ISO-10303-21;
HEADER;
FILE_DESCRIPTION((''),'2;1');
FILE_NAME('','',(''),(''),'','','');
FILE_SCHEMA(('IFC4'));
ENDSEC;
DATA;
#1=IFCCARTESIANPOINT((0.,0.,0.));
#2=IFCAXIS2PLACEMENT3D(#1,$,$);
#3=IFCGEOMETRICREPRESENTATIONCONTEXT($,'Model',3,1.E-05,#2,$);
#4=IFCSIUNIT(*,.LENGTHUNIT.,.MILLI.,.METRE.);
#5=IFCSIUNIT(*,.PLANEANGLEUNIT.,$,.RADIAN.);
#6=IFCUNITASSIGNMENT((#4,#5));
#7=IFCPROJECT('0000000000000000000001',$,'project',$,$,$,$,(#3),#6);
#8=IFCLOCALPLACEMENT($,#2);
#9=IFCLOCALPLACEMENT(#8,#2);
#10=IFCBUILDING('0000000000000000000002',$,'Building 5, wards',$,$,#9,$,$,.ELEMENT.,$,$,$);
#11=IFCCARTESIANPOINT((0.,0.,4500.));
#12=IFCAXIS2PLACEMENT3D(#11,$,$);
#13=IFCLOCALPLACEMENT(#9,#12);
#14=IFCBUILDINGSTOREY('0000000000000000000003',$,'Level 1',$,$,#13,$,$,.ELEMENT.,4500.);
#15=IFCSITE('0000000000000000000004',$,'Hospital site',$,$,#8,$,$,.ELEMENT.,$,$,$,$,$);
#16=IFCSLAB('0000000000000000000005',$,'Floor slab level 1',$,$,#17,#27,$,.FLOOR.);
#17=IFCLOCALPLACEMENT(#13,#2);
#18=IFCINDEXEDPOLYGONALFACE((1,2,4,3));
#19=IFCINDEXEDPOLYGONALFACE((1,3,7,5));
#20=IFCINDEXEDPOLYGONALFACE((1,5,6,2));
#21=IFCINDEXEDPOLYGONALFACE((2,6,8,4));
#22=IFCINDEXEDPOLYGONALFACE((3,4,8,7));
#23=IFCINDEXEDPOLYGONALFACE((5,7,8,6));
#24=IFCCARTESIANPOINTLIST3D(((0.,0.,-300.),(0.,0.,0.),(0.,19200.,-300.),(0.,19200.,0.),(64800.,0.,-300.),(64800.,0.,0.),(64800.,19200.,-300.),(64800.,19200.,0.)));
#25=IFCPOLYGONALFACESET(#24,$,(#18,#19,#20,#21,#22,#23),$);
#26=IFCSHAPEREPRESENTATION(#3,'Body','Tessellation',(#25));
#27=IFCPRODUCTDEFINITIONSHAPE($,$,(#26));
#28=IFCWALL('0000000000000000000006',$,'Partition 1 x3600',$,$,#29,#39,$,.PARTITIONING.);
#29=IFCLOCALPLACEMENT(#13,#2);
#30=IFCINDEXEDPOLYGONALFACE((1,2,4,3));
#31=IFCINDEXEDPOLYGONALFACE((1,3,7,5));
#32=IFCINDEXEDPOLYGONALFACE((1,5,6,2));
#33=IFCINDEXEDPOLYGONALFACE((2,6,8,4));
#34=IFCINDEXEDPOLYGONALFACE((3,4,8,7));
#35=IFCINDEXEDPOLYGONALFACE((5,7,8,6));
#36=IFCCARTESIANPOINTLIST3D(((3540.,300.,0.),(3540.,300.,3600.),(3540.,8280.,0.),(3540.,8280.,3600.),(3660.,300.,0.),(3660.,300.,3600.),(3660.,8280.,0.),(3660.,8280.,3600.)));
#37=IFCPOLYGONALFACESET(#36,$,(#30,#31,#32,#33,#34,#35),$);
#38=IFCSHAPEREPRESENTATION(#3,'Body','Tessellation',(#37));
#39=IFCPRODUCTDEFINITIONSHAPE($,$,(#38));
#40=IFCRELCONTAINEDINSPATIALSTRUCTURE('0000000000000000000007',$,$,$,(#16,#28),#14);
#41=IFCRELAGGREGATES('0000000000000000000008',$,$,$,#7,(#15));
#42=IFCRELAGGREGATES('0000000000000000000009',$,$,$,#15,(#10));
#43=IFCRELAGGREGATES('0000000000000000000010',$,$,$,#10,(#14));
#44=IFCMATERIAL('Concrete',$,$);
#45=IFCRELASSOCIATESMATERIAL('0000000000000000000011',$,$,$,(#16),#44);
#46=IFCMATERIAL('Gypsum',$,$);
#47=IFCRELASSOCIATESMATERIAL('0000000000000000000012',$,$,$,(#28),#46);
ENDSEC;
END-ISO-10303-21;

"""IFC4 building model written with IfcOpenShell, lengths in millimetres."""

from ifc_helpers import new_model, si_unit, frame, frame_2d, origin, place, context, project, spatial, rectangle, extrude, material, element, save


model = new_model("IFC4")

# Units and contexts
model_context = context("Model", 3, precision=1e-05, world=origin())
ifc_project = project(units=[si_unit("LENGTHUNIT", "METRE", prefix="MILLI"), si_unit("PLANEANGLEUNIT", "RADIAN")], contexts=[model_context])

# Site, building, storey
site_placement = place(None, origin())
site = spatial("IfcSite", under=ifc_project, at=site_placement, Name="Hospital site", CompositionType="ELEMENT")
building_placement = place(site_placement, origin())
building = spatial("IfcBuilding", under=site, at=building_placement, Name="Building 5, wards", CompositionType="ELEMENT")
storey_placement = place(building_placement, frame((0.0, 0.0, 4500.0)))
storey = spatial("IfcBuildingStorey", under=building, at=storey_placement, Name="Level 1", CompositionType="ELEMENT", Elevation=4500.0)

# Slab
ifc_material_1 = material(Name="Concrete")
slab_placement = place(storey_placement, origin())
element("IfcSlab", 1, at=slab_placement, inside=storey, material=ifc_material_1, Name="Floor slab level 1", PredefinedType="FLOOR", context=model_context, shape_type="SweptSolid", body=[
    extrude(rectangle(XDim=64800.0, YDim=19200.0, at=frame_2d((32400.0, 9600.0))), frame((0.0, 0.0, -300.0)), (0.0, 0.0, 1.0), 300.0),
])

# Wall
ifc_material_2 = material(Name="Gypsum")
wall_1_placement = place(storey_placement, frame((3660.0, 300.0, 0.0), x_axis=(0.0, 1.0, 0.0)))
element("IfcWall", 2, at=wall_1_placement, inside=storey, material=ifc_material_2, Name="Partition 1 x3600", PredefinedType="PARTITIONING", context=model_context, shape_type="SweptSolid", body=[
    extrude(rectangle(XDim=7980.0, YDim=120.0, at=frame_2d((3990.0, 60.0))), origin(), (0.0, 0.0, 1.0), 3600.0),
])

save(model, "model.ifc")
